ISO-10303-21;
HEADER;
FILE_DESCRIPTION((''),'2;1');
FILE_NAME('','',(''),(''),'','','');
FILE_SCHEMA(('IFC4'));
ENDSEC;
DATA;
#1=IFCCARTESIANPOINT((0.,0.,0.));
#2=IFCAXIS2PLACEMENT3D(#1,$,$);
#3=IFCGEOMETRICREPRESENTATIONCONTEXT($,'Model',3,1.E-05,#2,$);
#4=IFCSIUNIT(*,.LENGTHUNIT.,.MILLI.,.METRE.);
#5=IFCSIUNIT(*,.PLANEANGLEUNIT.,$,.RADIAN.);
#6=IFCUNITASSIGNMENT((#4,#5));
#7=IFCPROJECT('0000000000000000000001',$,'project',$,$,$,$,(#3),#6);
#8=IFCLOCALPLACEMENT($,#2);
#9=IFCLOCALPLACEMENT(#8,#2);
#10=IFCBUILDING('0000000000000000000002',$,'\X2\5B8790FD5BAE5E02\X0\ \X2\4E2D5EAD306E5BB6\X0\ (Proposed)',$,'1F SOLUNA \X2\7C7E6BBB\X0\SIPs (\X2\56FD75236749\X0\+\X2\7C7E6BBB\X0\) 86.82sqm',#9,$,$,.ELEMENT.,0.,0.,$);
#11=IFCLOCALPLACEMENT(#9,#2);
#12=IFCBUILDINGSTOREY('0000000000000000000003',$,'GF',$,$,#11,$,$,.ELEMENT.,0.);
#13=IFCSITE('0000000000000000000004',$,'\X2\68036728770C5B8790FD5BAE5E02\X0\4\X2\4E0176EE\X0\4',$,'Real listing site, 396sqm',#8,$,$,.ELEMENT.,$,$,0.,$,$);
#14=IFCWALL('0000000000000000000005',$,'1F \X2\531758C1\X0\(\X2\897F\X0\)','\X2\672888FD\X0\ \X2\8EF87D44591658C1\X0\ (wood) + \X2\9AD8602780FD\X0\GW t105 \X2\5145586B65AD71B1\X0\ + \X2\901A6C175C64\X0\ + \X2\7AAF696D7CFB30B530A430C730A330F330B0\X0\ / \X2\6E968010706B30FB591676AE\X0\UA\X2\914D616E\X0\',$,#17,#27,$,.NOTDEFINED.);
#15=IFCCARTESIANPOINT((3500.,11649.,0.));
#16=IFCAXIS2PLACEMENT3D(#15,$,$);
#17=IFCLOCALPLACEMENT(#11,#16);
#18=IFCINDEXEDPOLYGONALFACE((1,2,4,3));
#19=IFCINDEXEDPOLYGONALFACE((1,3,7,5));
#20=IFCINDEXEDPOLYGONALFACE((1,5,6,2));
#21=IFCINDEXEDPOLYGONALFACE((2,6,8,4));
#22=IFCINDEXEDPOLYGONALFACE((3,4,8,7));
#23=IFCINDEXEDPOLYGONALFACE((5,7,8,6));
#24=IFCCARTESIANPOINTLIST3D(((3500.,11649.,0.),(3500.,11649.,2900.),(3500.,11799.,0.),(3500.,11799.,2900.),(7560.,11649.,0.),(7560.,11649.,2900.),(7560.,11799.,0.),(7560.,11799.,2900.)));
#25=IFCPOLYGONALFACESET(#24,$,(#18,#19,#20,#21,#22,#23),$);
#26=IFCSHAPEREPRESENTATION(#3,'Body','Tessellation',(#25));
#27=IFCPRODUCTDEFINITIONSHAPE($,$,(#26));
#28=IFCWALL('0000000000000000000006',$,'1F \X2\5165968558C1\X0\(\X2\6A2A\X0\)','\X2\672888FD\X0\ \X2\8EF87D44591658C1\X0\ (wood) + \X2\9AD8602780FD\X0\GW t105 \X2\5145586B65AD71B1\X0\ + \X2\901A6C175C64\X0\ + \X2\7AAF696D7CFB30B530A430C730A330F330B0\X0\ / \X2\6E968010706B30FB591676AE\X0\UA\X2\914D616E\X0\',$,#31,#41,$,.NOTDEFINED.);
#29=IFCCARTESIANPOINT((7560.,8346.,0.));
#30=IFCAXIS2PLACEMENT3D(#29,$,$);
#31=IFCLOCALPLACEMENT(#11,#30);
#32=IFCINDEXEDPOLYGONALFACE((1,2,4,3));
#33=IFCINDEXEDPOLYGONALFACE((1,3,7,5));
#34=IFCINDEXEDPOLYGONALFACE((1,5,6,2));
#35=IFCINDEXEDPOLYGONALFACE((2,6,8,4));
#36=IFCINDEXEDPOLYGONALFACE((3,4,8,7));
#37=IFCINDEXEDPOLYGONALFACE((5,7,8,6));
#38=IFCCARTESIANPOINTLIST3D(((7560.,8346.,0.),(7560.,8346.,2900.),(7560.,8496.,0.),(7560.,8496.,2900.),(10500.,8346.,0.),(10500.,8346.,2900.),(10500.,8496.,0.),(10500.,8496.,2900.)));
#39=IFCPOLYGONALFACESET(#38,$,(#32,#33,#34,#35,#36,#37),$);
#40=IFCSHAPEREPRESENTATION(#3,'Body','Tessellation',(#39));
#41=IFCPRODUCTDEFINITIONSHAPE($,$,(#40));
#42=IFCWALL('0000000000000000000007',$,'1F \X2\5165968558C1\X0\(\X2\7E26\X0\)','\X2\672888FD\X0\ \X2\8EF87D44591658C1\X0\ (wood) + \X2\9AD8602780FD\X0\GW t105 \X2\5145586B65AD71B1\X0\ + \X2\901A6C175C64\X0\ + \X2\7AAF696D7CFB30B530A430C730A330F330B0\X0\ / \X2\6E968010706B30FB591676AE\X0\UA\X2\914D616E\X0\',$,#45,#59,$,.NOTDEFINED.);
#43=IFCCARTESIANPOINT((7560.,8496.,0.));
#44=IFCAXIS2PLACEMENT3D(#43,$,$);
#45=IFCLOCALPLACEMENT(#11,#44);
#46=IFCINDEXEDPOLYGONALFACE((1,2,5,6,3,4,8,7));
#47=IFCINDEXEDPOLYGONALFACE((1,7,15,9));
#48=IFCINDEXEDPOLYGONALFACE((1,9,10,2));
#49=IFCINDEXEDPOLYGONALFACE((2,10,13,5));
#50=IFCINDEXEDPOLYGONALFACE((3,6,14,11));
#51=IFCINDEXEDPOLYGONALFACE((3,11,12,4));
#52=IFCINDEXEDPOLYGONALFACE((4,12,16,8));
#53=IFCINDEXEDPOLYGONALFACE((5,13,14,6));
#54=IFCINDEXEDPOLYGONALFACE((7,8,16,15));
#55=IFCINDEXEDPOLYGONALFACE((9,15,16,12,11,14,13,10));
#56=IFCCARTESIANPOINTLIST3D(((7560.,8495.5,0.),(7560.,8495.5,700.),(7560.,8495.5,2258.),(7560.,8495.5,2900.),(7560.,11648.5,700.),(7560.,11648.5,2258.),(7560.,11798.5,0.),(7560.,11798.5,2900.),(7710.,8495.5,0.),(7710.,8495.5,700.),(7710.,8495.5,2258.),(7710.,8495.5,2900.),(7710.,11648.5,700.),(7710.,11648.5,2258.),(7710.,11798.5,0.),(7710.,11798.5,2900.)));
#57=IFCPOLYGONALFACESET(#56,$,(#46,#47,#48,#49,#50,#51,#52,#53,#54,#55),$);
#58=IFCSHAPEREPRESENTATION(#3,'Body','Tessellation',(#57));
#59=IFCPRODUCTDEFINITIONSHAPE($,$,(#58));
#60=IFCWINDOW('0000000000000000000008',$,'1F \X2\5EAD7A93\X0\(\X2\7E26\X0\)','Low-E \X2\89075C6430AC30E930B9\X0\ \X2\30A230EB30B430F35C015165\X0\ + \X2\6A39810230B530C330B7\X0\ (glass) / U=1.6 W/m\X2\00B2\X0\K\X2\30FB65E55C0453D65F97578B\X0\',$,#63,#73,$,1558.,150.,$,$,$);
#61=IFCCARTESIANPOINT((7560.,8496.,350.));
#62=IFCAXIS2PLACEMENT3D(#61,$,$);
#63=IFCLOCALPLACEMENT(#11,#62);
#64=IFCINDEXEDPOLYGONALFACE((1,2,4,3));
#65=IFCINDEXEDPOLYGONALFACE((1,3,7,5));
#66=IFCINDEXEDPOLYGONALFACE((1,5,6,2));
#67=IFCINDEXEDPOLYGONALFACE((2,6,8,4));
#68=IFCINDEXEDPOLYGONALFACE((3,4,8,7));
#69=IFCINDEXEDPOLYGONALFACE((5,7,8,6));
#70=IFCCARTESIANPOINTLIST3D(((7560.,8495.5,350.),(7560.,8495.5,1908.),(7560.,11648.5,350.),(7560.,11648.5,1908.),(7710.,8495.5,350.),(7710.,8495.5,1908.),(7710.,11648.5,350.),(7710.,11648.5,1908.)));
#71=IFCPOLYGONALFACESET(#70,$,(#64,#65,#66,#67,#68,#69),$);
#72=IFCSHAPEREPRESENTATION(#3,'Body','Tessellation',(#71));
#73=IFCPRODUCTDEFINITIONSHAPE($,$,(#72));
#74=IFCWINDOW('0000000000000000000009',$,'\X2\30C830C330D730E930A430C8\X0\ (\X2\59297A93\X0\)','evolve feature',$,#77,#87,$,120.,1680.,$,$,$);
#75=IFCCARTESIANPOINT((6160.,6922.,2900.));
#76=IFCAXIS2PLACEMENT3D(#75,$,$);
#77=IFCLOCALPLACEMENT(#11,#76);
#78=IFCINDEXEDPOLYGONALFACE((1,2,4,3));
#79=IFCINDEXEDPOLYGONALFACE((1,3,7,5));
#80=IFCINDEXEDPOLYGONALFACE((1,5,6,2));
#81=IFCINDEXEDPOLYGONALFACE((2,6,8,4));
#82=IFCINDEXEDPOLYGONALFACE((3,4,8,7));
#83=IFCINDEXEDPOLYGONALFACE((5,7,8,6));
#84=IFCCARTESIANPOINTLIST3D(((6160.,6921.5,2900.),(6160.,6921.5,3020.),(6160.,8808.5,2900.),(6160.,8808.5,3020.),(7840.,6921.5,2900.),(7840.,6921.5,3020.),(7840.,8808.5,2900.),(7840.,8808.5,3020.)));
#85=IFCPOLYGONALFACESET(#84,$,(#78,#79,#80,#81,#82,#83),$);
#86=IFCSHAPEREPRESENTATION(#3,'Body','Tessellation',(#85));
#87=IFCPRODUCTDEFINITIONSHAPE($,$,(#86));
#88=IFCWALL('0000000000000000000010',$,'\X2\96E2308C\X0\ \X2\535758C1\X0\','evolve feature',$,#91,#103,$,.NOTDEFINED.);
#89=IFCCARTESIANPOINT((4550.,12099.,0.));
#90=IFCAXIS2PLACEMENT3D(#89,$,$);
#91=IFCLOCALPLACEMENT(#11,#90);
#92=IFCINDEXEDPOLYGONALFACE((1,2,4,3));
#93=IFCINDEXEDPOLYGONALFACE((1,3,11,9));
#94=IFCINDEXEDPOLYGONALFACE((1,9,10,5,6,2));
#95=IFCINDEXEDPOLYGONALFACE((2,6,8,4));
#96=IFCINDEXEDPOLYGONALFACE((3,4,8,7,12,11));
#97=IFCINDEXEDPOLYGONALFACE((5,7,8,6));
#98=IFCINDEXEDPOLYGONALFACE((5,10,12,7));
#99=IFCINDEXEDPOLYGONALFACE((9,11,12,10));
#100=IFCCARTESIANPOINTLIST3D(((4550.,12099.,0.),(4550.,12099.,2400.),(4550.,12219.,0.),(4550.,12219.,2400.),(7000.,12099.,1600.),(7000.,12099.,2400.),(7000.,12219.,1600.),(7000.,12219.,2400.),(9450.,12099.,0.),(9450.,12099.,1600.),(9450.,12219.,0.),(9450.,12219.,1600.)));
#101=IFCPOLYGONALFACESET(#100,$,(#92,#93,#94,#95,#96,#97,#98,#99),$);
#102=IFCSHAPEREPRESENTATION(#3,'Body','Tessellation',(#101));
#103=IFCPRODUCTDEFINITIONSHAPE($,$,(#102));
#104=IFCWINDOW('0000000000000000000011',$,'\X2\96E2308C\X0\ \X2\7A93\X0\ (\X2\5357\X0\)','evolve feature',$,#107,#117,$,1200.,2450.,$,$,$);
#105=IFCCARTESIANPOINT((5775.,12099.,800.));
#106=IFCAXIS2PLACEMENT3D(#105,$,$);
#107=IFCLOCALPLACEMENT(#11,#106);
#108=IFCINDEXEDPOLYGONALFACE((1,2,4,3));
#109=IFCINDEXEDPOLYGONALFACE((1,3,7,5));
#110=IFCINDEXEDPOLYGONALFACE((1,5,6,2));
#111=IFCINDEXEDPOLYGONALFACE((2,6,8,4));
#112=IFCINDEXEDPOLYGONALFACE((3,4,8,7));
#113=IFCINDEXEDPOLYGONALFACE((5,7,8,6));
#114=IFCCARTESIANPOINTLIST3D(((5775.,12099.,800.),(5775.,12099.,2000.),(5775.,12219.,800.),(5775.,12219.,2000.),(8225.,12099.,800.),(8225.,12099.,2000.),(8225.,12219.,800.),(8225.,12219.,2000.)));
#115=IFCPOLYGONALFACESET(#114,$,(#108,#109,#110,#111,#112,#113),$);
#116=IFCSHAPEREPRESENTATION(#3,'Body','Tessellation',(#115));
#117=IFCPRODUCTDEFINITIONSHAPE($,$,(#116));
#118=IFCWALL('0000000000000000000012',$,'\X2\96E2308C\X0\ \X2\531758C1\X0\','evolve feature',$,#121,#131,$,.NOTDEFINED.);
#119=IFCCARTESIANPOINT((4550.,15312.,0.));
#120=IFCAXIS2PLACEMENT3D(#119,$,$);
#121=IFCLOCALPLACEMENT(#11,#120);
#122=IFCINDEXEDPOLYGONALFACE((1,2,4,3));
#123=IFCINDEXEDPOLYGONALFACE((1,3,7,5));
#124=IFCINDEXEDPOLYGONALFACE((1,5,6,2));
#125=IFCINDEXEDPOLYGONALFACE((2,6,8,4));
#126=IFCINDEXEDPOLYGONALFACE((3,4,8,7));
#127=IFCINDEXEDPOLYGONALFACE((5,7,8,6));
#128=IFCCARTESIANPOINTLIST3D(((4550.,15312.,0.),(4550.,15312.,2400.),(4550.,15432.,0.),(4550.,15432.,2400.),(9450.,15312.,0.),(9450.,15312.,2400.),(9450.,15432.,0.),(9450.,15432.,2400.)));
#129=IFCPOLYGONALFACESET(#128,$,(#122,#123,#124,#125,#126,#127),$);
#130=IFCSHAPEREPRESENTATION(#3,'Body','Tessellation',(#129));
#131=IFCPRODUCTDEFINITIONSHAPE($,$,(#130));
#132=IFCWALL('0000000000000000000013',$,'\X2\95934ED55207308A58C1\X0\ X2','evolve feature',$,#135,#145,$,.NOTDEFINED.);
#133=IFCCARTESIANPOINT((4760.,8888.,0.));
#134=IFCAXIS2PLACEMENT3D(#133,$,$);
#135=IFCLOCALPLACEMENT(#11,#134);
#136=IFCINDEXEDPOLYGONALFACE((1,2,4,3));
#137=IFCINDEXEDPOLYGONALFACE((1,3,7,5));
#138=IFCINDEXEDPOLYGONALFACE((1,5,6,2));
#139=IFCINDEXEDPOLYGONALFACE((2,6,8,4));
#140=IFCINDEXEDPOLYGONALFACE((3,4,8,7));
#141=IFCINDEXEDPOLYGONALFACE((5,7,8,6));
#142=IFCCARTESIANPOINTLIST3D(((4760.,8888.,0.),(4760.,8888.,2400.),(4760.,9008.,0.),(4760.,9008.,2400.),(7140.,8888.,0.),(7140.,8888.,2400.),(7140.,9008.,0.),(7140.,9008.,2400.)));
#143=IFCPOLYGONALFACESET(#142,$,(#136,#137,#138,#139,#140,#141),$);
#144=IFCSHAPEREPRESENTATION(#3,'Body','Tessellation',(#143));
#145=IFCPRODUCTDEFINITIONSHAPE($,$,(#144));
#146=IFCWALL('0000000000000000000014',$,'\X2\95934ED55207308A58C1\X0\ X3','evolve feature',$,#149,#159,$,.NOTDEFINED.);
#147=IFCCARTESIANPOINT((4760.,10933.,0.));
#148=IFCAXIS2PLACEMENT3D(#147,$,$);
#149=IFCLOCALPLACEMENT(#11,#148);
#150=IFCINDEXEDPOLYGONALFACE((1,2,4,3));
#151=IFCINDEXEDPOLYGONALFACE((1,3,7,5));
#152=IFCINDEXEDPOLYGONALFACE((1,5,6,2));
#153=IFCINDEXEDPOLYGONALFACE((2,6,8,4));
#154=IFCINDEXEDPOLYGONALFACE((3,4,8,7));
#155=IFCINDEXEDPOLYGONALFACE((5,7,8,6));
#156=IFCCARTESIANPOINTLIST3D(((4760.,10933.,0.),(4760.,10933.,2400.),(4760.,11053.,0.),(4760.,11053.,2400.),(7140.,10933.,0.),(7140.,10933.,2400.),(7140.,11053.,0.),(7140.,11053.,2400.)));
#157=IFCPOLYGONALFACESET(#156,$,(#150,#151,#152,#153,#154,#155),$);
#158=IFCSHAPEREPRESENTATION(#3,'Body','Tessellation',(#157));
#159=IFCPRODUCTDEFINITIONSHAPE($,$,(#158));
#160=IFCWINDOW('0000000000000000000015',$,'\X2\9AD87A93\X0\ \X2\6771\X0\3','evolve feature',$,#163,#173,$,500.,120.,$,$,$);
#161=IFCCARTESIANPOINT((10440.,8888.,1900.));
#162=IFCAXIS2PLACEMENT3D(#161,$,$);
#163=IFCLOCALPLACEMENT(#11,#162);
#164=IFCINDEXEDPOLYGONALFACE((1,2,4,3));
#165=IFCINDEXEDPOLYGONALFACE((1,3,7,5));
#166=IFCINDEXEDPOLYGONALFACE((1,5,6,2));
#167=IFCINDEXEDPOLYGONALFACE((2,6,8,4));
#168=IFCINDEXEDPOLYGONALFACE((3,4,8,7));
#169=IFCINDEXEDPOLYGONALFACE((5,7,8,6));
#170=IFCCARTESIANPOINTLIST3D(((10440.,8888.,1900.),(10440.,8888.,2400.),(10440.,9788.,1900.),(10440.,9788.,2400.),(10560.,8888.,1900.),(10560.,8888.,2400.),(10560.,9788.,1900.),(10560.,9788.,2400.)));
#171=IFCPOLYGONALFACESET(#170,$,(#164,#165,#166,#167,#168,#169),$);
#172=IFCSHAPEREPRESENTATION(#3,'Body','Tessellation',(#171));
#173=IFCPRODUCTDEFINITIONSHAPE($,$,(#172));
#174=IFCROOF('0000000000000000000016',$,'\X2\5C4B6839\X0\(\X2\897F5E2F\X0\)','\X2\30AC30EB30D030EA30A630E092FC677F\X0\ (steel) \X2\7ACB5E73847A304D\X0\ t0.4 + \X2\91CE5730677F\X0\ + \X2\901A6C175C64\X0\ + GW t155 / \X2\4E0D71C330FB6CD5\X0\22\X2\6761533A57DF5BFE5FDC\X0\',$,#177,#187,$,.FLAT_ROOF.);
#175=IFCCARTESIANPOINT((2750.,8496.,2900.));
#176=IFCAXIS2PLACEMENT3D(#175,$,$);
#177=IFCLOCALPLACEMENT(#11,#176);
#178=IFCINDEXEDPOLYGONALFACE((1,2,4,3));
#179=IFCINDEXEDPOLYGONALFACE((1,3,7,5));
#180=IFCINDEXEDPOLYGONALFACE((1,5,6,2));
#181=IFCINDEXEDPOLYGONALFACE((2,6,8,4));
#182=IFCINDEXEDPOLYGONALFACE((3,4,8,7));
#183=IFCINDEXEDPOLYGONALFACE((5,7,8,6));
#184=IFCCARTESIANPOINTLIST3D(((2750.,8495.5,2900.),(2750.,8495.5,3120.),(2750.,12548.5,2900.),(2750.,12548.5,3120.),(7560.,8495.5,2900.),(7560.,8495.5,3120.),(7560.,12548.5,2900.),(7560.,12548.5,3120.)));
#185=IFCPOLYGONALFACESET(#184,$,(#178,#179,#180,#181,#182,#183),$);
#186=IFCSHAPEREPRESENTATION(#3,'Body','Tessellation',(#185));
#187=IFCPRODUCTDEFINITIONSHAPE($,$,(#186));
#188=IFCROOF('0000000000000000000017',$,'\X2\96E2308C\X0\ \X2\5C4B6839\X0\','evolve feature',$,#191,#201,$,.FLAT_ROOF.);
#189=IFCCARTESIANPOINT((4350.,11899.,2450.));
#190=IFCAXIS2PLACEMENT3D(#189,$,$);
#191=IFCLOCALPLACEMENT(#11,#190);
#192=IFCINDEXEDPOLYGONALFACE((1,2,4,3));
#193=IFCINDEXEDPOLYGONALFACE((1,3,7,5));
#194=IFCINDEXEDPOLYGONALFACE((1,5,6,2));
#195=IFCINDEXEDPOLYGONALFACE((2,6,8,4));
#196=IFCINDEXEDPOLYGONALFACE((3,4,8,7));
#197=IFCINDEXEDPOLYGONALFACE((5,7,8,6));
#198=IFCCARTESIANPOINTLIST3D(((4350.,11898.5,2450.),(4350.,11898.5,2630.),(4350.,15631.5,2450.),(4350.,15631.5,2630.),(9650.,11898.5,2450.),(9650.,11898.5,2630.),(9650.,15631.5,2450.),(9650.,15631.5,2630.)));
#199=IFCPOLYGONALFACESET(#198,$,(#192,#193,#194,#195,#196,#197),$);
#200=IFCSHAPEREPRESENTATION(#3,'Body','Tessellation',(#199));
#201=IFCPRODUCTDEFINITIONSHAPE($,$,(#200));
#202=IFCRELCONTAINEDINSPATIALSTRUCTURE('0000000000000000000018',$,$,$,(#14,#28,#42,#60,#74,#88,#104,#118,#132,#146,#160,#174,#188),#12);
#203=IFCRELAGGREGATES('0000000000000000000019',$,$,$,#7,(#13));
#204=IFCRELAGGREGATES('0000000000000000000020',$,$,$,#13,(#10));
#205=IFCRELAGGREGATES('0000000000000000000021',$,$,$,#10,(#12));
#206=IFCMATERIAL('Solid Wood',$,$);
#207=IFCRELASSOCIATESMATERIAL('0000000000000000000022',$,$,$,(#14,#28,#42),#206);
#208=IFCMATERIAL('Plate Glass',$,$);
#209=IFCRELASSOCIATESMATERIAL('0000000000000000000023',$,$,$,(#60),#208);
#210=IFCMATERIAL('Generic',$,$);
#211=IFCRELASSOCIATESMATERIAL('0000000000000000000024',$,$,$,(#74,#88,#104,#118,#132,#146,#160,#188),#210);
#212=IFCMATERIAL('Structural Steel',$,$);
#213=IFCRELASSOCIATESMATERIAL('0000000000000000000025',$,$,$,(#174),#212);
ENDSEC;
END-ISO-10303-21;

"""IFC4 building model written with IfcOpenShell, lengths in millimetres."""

from ifc_helpers import new_model, si_unit, frame, frame_2d, origin, place, context, project, spatial, rectangle, extrude, material, element, fill, save


model = new_model("IFC4")

# Units and contexts
model_context = context("Model", 3, precision=1e-05, world=origin())
ifc_project = project(units=[si_unit("LENGTHUNIT", "METRE", prefix="MILLI"), si_unit("PLANEANGLEUNIT", "RADIAN")], contexts=[model_context])

# Site, building, storey
site_placement = place(None, origin())
site = spatial("IfcSite", under=ifc_project, at=site_placement, Name="栃木県宇都宮市4丁目4", ObjectType="Real listing site, 396sqm", CompositionType="ELEMENT", RefElevation=0.0)
building_placement = place(site_placement, origin())
building = spatial("IfcBuilding", under=site, at=building_placement, Name="宇都宮市 中庭の家 (Proposed)", ObjectType="1F SOLUNA 籾殻SIPs (国産杉+籾殻) 86.82sqm", CompositionType="ELEMENT", ElevationOfRefHeight=0.0, ElevationOfTerrain=0.0)
storey_placement = place(building_placement, origin())
storey = spatial("IfcBuildingStorey", under=building, at=storey_placement, Name="GF", CompositionType="ELEMENT", Elevation=0.0)

# Shared definitions
ifc_material_1 = material(Name="Solid Wood")
ifc_material_2 = material(Name="Generic")

# Walls
wall_1_placement = place(storey_placement, frame((3500.0, 11649.0, 0.0)))
element("IfcWall", 1, at=wall_1_placement, inside=storey, material=ifc_material_1, Name="1F 北壁(西)", Description="木製 軸組外壁 (wood) + 高性能GW t105 充填断熱 + 通気層 + 窯業系サイディング / 準耐火・外皮UA配慮", PredefinedType="NOTDEFINED", context=model_context, shape_type="SweptSolid", body=[
    extrude(rectangle(XDim=4060.0, YDim=150.0, at=frame_2d((2030.0, 75.0))), frame((3500.0, 11649.0, 0.0)), (0.0, 0.0, 1.0), 2900.0),
])
wall_2_placement = place(storey_placement, frame((7560.0, 8346.0, 0.0)))
element("IfcWall", 2, at=wall_2_placement, inside=storey, material=ifc_material_1, Name="1F 入隅壁(横)", Description="木製 軸組外壁 (wood) + 高性能GW t105 充填断熱 + 通気層 + 窯業系サイディング / 準耐火・外皮UA配慮", PredefinedType="NOTDEFINED", context=model_context, shape_type="SweptSolid", body=[
    extrude(rectangle(XDim=2940.0, YDim=150.0, at=frame_2d((1470.0, 75.0))), frame((7560.0, 8346.0, 0.0)), (0.0, 0.0, 1.0), 2900.0),
])

# Wall, opening, window
wall_3_placement = place(storey_placement, frame((7560.0, 8496.0, 0.0)))
wall_3 = element("IfcWall", 3, at=wall_3_placement, inside=storey, material=ifc_material_1, Name="1F 入隅壁(縦)", Description="木製 軸組外壁 (wood) + 高性能GW t105 充填断熱 + 通気層 + 窯業系サイディング / 準耐火・外皮UA配慮", PredefinedType="NOTDEFINED", context=model_context, shape_type="SweptSolid", body=[
    extrude(rectangle(XDim=150.0, YDim=3303.0, at=frame_2d((75.0, 1651.0))), frame((7560.0, 8496.0, 0.0)), (0.0, 0.0, 1.0), 2900.0),
])
opening_1_placement = place(storey_placement, frame((7560.0, 8496.0, 350.0)))
opening_1 = element("IfcOpeningElement", 4, at=opening_1_placement, cuts=wall_3, PredefinedType="NOTDEFINED", context=model_context, shape_type="SweptSolid", body=[
    extrude(rectangle(XDim=150.0, YDim=3153.0, at=frame_2d((75.0, 1576.0))), frame((7560.0, 8496.0, 350.0)), (0.0, 0.0, 1.0), 1558.0),
])
ifc_material_3 = material(Name="Plate Glass")
window_1_placement = place(storey_placement, frame((7560.0, 8496.0, 350.0)))
window_1 = element("IfcWindow", 5, at=window_1_placement, inside=storey, material=ifc_material_3, Name="1F 庭窓(縦)", Description="Low-E 複層ガラス アルゴン封入 + 樹脂サッシ (glass) / U=1.6 W/m²K・日射取得型", OverallHeight=1558.0, OverallWidth=150.0, context=model_context, shape_type="SweptSolid", body=[
    extrude(rectangle(XDim=150.0, YDim=3153.0, at=frame_2d((75.0, 1576.0))), frame((7560.0, 8496.0, 350.0)), (0.0, 0.0, 1.0), 1558.0),
])
fill(opening_1, window_1)

# Window
window_2_placement = place(storey_placement, frame((6160.0, 6922.0, 2900.0)))
element("IfcWindow", 6, at=window_2_placement, inside=storey, material=ifc_material_2, Name="トップライト (天窓)", Description="evolve feature", OverallHeight=120.0, OverallWidth=1680.0, context=model_context, shape_type="SweptSolid", body=[
    extrude(rectangle(XDim=1680.0, YDim=1887.0, at=frame_2d((840.0, 943.0))), frame((6160.0, 6922.0, 2900.0)), (0.0, 0.0, 1.0), 120.0),
])

# Wall, opening, window
wall_4_placement = place(storey_placement, frame((4550.0, 12099.0, 0.0)))
wall_4 = element("IfcWall", 7, at=wall_4_placement, inside=storey, material=ifc_material_2, Name="離れ 南壁", Description="evolve feature", PredefinedType="NOTDEFINED", context=model_context, shape_type="SweptSolid", body=[
    extrude(rectangle(XDim=4900.0, YDim=120.0, at=frame_2d((2450.0, 60.0))), frame((4550.0, 12099.0, 0.0)), (0.0, 0.0, 1.0), 2400.0),
])
opening_2_placement = place(storey_placement, frame((5775.0, 12099.0, 800.0)))
opening_2 = element("IfcOpeningElement", 8, at=opening_2_placement, cuts=wall_4, PredefinedType="NOTDEFINED", context=model_context, shape_type="SweptSolid", body=[
    extrude(rectangle(XDim=2450.0, YDim=120.0, at=frame_2d((1225.0, 60.0))), frame((5775.0, 12099.0, 800.0)), (0.0, 0.0, 1.0), 1200.0),
])
window_3_placement = place(storey_placement, frame((5775.0, 12099.0, 800.0)))
window_3 = element("IfcWindow", 9, at=window_3_placement, inside=storey, material=ifc_material_2, Name="離れ 窓 (南)", Description="evolve feature", OverallHeight=1200.0, OverallWidth=2450.0, context=model_context, shape_type="SweptSolid", body=[
    extrude(rectangle(XDim=2450.0, YDim=120.0, at=frame_2d((1225.0, 60.0))), frame((5775.0, 12099.0, 800.0)), (0.0, 0.0, 1.0), 1200.0),
])
fill(opening_2, window_3)

# Walls
wall_5_placement = place(storey_placement, frame((4550.0, 15312.0, 0.0)))
element("IfcWall", 10, at=wall_5_placement, inside=storey, material=ifc_material_2, Name="離れ 北壁", Description="evolve feature", PredefinedType="NOTDEFINED", context=model_context, shape_type="SweptSolid", body=[
    extrude(rectangle(XDim=4900.0, YDim=120.0, at=frame_2d((2450.0, 60.0))), frame((4550.0, 15312.0, 0.0)), (0.0, 0.0, 1.0), 2400.0),
])
wall_6_placement = place(storey_placement, frame((4760.0, 8888.0, 0.0)))
element("IfcWall", 11, at=wall_6_placement, inside=storey, material=ifc_material_2, Name="間仕切り壁 X2", Description="evolve feature", PredefinedType="NOTDEFINED", context=model_context, shape_type="SweptSolid", body=[
    extrude(rectangle(XDim=2380.0, YDim=120.0, at=frame_2d((1190.0, 60.0))), frame((4760.0, 8888.0, 0.0)), (0.0, 0.0, 1.0), 2400.0),
])
wall_7_placement = place(storey_placement, frame((4760.0, 10933.0, 0.0)))
element("IfcWall", 12, at=wall_7_placement, inside=storey, material=ifc_material_2, Name="間仕切り壁 X3", Description="evolve feature", PredefinedType="NOTDEFINED", context=model_context, shape_type="SweptSolid", body=[
    extrude(rectangle(XDim=2380.0, YDim=120.0, at=frame_2d((1190.0, 60.0))), frame((4760.0, 10933.0, 0.0)), (0.0, 0.0, 1.0), 2400.0),
])

# Window
window_4_placement = place(storey_placement, frame((10440.0, 8888.0, 1900.0)))
element("IfcWindow", 13, at=window_4_placement, inside=storey, material=ifc_material_2, Name="高窓 東3", Description="evolve feature", OverallHeight=500.0, OverallWidth=120.0, context=model_context, shape_type="SweptSolid", body=[
    extrude(rectangle(XDim=120.0, YDim=900.0, at=frame_2d((60.0, 450.0))), frame((10440.0, 8888.0, 1900.0)), (0.0, 0.0, 1.0), 500.0),
])

# Roofs
ifc_material_4 = material(Name="Structural Steel")
roof_1_placement = place(storey_placement, frame((2750.0, 8496.0, 2900.0)))
element("IfcRoof", 14, at=roof_1_placement, inside=storey, material=ifc_material_4, Name="屋根(西帯)", Description="ガルバリウム鋼板 (steel) 立平葺き t0.4 + 野地板 + 通気層 + GW t155 / 不燃・法22条区域対応", PredefinedType="FLAT_ROOF", context=model_context, shape_type="SweptSolid", body=[
    extrude(rectangle(XDim=4810.0, YDim=4053.0, at=frame_2d((2405.0, 2026.0))), frame((2750.0, 8496.0, 2900.0)), (0.0, 0.0, 1.0), 220.0),
])
roof_2_placement = place(storey_placement, frame((4350.0, 11899.0, 2450.0)))
element("IfcRoof", 15, at=roof_2_placement, inside=storey, material=ifc_material_2, Name="離れ 屋根", Description="evolve feature", PredefinedType="FLAT_ROOF", context=model_context, shape_type="SweptSolid", body=[
    extrude(rectangle(XDim=5300.0, YDim=3733.0, at=frame_2d((2650.0, 1866.0))), frame((4350.0, 11899.0, 2450.0)), (0.0, 0.0, 1.0), 180.0),
])

save(model, "model.ifc")
